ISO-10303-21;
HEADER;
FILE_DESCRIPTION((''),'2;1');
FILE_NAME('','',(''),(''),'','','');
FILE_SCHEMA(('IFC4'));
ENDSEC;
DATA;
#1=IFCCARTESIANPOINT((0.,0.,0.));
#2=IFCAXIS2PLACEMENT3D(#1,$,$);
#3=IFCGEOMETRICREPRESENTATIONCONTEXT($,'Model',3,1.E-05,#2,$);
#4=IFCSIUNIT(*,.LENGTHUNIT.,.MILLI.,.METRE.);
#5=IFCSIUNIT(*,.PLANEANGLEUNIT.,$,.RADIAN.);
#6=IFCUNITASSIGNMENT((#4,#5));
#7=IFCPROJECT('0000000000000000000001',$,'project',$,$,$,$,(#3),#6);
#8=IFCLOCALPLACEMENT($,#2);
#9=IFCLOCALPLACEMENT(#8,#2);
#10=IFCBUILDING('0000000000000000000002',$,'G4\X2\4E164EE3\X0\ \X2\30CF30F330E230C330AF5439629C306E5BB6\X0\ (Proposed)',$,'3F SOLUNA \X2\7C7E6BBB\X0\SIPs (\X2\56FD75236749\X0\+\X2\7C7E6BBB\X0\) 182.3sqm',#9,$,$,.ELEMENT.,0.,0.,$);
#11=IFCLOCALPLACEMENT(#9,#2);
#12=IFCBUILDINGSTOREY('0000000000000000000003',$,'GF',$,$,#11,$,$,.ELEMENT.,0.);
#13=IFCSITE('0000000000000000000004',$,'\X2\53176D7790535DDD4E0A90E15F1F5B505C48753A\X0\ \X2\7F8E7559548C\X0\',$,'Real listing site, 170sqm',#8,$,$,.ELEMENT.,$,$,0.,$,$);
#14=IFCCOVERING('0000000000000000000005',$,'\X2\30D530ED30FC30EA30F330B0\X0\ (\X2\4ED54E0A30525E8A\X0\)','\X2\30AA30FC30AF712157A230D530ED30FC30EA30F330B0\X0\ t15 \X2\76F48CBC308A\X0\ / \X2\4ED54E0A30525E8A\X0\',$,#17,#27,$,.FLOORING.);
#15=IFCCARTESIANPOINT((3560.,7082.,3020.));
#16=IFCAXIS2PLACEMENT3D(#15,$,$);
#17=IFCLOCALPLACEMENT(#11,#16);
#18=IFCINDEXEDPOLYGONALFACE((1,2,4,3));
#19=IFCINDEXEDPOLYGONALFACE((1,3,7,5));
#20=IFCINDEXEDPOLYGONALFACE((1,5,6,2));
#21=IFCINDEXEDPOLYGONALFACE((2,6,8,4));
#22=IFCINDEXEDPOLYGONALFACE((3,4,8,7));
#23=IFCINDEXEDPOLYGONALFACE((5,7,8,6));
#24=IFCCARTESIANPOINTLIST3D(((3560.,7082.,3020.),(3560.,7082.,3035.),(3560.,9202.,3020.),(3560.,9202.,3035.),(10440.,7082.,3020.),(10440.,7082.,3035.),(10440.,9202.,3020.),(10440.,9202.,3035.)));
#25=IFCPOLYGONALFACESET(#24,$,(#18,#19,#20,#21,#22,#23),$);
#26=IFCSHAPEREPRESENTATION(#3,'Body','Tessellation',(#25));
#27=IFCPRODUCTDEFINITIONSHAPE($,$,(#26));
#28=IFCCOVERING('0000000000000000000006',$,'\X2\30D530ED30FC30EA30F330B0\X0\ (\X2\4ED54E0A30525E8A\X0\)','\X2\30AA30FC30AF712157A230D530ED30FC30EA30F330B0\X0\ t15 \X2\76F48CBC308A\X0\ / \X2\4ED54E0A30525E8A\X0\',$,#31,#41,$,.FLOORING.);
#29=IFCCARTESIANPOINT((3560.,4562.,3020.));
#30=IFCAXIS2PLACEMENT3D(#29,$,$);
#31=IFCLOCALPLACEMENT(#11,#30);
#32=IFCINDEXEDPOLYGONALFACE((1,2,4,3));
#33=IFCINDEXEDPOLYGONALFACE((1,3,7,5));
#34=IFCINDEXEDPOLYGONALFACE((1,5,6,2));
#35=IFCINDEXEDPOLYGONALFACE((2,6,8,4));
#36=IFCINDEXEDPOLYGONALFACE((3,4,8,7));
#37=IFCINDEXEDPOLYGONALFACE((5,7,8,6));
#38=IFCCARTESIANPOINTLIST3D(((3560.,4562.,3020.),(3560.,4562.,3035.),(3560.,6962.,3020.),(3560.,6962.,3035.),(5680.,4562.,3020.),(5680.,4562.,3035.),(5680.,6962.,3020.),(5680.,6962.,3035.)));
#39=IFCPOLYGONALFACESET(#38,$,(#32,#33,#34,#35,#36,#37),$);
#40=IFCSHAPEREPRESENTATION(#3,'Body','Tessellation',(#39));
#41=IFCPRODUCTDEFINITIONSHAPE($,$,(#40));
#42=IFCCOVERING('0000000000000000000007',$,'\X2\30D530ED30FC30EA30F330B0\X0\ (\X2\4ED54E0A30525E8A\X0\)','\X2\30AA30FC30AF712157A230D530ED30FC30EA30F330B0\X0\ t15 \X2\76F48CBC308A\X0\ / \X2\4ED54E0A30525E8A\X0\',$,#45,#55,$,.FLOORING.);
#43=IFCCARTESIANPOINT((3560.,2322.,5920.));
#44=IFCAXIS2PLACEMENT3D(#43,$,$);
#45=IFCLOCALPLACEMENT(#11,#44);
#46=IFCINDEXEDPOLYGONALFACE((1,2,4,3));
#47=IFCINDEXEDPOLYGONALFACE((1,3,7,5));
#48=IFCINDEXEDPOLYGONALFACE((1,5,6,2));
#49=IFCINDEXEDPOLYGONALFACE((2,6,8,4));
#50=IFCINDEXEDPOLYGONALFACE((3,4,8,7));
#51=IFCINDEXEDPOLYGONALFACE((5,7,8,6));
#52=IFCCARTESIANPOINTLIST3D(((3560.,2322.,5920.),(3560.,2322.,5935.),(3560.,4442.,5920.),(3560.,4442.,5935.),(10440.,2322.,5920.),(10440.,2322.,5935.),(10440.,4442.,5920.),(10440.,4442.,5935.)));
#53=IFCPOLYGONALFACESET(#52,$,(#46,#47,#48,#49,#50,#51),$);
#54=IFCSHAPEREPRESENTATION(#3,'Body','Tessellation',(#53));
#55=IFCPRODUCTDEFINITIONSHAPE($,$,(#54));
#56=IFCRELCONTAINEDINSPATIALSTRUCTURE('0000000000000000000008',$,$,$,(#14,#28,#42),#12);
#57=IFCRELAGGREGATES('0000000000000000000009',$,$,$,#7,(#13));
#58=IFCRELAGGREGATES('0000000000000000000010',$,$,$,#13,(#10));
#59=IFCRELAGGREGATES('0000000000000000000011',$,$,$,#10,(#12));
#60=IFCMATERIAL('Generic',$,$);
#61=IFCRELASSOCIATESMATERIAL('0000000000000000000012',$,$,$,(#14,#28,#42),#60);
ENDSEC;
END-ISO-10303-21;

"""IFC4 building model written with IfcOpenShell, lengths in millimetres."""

from ifc_helpers import new_model, si_unit, frame, frame_2d, origin, place, context, project, spatial, rectangle, extrude, material, element, save


model = new_model("IFC4")

# Units and contexts
model_context = context("Model", 3, precision=1e-05, world=origin())
ifc_project = project(units=[si_unit("LENGTHUNIT", "METRE", prefix="MILLI"), si_unit("PLANEANGLEUNIT", "RADIAN")], contexts=[model_context])

# Site, building, storey
site_placement = place(None, origin())
site = spatial("IfcSite", under=ifc_project, at=site_placement, Name="北海道川上郡弟子屈町 美留和", ObjectType="Real listing site, 170sqm", CompositionType="ELEMENT", RefElevation=0.0)
building_placement = place(site_placement, origin())
building = spatial("IfcBuilding", under=site, at=building_placement, Name="G4世代 ハンモック吹抜の家 (Proposed)", ObjectType="3F SOLUNA 籾殻SIPs (国産杉+籾殻) 182.3sqm", CompositionType="ELEMENT", ElevationOfRefHeight=0.0, ElevationOfTerrain=0.0)
storey_placement = place(building_placement, origin())
storey = spatial("IfcBuildingStorey", under=building, at=storey_placement, Name="GF", CompositionType="ELEMENT", Elevation=0.0)

# Shared definitions
ifc_material_1 = material(Name="Generic")

# Coverings
covering_1_placement = place(storey_placement, frame((3560.0, 7082.0, 3020.0)))
element("IfcCovering", 1, at=covering_1_placement, inside=storey, material=ifc_material_1, Name="フローリング (仕上げ床)", Description="オーク無垢フローリング t15 直貼り / 仕上げ床", PredefinedType="FLOORING", context=model_context, shape_type="SweptSolid", body=[
    extrude(rectangle(XDim=6880.0, YDim=2120.0, at=frame_2d((3440.0, 1060.0))), frame((3560.0, 7082.0, 3020.0)), (0.0, 0.0, 1.0), 15.0),
])
covering_2_placement = place(storey_placement, frame((3560.0, 4562.0, 3020.0)))
element("IfcCovering", 2, at=covering_2_placement, inside=storey, material=ifc_material_1, Name="フローリング (仕上げ床)", Description="オーク無垢フローリング t15 直貼り / 仕上げ床", PredefinedType="FLOORING", context=model_context, shape_type="SweptSolid", body=[
    extrude(rectangle(XDim=2120.0, YDim=2400.0, at=frame_2d((1060.0, 1200.0))), frame((3560.0, 4562.0, 3020.0)), (0.0, 0.0, 1.0), 15.0),
])
covering_3_placement = place(storey_placement, frame((3560.0, 2322.0, 5920.0)))
element("IfcCovering", 3, at=covering_3_placement, inside=storey, material=ifc_material_1, Name="フローリング (仕上げ床)", Description="オーク無垢フローリング t15 直貼り / 仕上げ床", PredefinedType="FLOORING", context=model_context, shape_type="SweptSolid", body=[
    extrude(rectangle(XDim=6880.0, YDim=2120.0, at=frame_2d((3440.0, 1060.0))), frame((3560.0, 2322.0, 5920.0)), (0.0, 0.0, 1.0), 15.0),
])

save(model, "model.ifc")
